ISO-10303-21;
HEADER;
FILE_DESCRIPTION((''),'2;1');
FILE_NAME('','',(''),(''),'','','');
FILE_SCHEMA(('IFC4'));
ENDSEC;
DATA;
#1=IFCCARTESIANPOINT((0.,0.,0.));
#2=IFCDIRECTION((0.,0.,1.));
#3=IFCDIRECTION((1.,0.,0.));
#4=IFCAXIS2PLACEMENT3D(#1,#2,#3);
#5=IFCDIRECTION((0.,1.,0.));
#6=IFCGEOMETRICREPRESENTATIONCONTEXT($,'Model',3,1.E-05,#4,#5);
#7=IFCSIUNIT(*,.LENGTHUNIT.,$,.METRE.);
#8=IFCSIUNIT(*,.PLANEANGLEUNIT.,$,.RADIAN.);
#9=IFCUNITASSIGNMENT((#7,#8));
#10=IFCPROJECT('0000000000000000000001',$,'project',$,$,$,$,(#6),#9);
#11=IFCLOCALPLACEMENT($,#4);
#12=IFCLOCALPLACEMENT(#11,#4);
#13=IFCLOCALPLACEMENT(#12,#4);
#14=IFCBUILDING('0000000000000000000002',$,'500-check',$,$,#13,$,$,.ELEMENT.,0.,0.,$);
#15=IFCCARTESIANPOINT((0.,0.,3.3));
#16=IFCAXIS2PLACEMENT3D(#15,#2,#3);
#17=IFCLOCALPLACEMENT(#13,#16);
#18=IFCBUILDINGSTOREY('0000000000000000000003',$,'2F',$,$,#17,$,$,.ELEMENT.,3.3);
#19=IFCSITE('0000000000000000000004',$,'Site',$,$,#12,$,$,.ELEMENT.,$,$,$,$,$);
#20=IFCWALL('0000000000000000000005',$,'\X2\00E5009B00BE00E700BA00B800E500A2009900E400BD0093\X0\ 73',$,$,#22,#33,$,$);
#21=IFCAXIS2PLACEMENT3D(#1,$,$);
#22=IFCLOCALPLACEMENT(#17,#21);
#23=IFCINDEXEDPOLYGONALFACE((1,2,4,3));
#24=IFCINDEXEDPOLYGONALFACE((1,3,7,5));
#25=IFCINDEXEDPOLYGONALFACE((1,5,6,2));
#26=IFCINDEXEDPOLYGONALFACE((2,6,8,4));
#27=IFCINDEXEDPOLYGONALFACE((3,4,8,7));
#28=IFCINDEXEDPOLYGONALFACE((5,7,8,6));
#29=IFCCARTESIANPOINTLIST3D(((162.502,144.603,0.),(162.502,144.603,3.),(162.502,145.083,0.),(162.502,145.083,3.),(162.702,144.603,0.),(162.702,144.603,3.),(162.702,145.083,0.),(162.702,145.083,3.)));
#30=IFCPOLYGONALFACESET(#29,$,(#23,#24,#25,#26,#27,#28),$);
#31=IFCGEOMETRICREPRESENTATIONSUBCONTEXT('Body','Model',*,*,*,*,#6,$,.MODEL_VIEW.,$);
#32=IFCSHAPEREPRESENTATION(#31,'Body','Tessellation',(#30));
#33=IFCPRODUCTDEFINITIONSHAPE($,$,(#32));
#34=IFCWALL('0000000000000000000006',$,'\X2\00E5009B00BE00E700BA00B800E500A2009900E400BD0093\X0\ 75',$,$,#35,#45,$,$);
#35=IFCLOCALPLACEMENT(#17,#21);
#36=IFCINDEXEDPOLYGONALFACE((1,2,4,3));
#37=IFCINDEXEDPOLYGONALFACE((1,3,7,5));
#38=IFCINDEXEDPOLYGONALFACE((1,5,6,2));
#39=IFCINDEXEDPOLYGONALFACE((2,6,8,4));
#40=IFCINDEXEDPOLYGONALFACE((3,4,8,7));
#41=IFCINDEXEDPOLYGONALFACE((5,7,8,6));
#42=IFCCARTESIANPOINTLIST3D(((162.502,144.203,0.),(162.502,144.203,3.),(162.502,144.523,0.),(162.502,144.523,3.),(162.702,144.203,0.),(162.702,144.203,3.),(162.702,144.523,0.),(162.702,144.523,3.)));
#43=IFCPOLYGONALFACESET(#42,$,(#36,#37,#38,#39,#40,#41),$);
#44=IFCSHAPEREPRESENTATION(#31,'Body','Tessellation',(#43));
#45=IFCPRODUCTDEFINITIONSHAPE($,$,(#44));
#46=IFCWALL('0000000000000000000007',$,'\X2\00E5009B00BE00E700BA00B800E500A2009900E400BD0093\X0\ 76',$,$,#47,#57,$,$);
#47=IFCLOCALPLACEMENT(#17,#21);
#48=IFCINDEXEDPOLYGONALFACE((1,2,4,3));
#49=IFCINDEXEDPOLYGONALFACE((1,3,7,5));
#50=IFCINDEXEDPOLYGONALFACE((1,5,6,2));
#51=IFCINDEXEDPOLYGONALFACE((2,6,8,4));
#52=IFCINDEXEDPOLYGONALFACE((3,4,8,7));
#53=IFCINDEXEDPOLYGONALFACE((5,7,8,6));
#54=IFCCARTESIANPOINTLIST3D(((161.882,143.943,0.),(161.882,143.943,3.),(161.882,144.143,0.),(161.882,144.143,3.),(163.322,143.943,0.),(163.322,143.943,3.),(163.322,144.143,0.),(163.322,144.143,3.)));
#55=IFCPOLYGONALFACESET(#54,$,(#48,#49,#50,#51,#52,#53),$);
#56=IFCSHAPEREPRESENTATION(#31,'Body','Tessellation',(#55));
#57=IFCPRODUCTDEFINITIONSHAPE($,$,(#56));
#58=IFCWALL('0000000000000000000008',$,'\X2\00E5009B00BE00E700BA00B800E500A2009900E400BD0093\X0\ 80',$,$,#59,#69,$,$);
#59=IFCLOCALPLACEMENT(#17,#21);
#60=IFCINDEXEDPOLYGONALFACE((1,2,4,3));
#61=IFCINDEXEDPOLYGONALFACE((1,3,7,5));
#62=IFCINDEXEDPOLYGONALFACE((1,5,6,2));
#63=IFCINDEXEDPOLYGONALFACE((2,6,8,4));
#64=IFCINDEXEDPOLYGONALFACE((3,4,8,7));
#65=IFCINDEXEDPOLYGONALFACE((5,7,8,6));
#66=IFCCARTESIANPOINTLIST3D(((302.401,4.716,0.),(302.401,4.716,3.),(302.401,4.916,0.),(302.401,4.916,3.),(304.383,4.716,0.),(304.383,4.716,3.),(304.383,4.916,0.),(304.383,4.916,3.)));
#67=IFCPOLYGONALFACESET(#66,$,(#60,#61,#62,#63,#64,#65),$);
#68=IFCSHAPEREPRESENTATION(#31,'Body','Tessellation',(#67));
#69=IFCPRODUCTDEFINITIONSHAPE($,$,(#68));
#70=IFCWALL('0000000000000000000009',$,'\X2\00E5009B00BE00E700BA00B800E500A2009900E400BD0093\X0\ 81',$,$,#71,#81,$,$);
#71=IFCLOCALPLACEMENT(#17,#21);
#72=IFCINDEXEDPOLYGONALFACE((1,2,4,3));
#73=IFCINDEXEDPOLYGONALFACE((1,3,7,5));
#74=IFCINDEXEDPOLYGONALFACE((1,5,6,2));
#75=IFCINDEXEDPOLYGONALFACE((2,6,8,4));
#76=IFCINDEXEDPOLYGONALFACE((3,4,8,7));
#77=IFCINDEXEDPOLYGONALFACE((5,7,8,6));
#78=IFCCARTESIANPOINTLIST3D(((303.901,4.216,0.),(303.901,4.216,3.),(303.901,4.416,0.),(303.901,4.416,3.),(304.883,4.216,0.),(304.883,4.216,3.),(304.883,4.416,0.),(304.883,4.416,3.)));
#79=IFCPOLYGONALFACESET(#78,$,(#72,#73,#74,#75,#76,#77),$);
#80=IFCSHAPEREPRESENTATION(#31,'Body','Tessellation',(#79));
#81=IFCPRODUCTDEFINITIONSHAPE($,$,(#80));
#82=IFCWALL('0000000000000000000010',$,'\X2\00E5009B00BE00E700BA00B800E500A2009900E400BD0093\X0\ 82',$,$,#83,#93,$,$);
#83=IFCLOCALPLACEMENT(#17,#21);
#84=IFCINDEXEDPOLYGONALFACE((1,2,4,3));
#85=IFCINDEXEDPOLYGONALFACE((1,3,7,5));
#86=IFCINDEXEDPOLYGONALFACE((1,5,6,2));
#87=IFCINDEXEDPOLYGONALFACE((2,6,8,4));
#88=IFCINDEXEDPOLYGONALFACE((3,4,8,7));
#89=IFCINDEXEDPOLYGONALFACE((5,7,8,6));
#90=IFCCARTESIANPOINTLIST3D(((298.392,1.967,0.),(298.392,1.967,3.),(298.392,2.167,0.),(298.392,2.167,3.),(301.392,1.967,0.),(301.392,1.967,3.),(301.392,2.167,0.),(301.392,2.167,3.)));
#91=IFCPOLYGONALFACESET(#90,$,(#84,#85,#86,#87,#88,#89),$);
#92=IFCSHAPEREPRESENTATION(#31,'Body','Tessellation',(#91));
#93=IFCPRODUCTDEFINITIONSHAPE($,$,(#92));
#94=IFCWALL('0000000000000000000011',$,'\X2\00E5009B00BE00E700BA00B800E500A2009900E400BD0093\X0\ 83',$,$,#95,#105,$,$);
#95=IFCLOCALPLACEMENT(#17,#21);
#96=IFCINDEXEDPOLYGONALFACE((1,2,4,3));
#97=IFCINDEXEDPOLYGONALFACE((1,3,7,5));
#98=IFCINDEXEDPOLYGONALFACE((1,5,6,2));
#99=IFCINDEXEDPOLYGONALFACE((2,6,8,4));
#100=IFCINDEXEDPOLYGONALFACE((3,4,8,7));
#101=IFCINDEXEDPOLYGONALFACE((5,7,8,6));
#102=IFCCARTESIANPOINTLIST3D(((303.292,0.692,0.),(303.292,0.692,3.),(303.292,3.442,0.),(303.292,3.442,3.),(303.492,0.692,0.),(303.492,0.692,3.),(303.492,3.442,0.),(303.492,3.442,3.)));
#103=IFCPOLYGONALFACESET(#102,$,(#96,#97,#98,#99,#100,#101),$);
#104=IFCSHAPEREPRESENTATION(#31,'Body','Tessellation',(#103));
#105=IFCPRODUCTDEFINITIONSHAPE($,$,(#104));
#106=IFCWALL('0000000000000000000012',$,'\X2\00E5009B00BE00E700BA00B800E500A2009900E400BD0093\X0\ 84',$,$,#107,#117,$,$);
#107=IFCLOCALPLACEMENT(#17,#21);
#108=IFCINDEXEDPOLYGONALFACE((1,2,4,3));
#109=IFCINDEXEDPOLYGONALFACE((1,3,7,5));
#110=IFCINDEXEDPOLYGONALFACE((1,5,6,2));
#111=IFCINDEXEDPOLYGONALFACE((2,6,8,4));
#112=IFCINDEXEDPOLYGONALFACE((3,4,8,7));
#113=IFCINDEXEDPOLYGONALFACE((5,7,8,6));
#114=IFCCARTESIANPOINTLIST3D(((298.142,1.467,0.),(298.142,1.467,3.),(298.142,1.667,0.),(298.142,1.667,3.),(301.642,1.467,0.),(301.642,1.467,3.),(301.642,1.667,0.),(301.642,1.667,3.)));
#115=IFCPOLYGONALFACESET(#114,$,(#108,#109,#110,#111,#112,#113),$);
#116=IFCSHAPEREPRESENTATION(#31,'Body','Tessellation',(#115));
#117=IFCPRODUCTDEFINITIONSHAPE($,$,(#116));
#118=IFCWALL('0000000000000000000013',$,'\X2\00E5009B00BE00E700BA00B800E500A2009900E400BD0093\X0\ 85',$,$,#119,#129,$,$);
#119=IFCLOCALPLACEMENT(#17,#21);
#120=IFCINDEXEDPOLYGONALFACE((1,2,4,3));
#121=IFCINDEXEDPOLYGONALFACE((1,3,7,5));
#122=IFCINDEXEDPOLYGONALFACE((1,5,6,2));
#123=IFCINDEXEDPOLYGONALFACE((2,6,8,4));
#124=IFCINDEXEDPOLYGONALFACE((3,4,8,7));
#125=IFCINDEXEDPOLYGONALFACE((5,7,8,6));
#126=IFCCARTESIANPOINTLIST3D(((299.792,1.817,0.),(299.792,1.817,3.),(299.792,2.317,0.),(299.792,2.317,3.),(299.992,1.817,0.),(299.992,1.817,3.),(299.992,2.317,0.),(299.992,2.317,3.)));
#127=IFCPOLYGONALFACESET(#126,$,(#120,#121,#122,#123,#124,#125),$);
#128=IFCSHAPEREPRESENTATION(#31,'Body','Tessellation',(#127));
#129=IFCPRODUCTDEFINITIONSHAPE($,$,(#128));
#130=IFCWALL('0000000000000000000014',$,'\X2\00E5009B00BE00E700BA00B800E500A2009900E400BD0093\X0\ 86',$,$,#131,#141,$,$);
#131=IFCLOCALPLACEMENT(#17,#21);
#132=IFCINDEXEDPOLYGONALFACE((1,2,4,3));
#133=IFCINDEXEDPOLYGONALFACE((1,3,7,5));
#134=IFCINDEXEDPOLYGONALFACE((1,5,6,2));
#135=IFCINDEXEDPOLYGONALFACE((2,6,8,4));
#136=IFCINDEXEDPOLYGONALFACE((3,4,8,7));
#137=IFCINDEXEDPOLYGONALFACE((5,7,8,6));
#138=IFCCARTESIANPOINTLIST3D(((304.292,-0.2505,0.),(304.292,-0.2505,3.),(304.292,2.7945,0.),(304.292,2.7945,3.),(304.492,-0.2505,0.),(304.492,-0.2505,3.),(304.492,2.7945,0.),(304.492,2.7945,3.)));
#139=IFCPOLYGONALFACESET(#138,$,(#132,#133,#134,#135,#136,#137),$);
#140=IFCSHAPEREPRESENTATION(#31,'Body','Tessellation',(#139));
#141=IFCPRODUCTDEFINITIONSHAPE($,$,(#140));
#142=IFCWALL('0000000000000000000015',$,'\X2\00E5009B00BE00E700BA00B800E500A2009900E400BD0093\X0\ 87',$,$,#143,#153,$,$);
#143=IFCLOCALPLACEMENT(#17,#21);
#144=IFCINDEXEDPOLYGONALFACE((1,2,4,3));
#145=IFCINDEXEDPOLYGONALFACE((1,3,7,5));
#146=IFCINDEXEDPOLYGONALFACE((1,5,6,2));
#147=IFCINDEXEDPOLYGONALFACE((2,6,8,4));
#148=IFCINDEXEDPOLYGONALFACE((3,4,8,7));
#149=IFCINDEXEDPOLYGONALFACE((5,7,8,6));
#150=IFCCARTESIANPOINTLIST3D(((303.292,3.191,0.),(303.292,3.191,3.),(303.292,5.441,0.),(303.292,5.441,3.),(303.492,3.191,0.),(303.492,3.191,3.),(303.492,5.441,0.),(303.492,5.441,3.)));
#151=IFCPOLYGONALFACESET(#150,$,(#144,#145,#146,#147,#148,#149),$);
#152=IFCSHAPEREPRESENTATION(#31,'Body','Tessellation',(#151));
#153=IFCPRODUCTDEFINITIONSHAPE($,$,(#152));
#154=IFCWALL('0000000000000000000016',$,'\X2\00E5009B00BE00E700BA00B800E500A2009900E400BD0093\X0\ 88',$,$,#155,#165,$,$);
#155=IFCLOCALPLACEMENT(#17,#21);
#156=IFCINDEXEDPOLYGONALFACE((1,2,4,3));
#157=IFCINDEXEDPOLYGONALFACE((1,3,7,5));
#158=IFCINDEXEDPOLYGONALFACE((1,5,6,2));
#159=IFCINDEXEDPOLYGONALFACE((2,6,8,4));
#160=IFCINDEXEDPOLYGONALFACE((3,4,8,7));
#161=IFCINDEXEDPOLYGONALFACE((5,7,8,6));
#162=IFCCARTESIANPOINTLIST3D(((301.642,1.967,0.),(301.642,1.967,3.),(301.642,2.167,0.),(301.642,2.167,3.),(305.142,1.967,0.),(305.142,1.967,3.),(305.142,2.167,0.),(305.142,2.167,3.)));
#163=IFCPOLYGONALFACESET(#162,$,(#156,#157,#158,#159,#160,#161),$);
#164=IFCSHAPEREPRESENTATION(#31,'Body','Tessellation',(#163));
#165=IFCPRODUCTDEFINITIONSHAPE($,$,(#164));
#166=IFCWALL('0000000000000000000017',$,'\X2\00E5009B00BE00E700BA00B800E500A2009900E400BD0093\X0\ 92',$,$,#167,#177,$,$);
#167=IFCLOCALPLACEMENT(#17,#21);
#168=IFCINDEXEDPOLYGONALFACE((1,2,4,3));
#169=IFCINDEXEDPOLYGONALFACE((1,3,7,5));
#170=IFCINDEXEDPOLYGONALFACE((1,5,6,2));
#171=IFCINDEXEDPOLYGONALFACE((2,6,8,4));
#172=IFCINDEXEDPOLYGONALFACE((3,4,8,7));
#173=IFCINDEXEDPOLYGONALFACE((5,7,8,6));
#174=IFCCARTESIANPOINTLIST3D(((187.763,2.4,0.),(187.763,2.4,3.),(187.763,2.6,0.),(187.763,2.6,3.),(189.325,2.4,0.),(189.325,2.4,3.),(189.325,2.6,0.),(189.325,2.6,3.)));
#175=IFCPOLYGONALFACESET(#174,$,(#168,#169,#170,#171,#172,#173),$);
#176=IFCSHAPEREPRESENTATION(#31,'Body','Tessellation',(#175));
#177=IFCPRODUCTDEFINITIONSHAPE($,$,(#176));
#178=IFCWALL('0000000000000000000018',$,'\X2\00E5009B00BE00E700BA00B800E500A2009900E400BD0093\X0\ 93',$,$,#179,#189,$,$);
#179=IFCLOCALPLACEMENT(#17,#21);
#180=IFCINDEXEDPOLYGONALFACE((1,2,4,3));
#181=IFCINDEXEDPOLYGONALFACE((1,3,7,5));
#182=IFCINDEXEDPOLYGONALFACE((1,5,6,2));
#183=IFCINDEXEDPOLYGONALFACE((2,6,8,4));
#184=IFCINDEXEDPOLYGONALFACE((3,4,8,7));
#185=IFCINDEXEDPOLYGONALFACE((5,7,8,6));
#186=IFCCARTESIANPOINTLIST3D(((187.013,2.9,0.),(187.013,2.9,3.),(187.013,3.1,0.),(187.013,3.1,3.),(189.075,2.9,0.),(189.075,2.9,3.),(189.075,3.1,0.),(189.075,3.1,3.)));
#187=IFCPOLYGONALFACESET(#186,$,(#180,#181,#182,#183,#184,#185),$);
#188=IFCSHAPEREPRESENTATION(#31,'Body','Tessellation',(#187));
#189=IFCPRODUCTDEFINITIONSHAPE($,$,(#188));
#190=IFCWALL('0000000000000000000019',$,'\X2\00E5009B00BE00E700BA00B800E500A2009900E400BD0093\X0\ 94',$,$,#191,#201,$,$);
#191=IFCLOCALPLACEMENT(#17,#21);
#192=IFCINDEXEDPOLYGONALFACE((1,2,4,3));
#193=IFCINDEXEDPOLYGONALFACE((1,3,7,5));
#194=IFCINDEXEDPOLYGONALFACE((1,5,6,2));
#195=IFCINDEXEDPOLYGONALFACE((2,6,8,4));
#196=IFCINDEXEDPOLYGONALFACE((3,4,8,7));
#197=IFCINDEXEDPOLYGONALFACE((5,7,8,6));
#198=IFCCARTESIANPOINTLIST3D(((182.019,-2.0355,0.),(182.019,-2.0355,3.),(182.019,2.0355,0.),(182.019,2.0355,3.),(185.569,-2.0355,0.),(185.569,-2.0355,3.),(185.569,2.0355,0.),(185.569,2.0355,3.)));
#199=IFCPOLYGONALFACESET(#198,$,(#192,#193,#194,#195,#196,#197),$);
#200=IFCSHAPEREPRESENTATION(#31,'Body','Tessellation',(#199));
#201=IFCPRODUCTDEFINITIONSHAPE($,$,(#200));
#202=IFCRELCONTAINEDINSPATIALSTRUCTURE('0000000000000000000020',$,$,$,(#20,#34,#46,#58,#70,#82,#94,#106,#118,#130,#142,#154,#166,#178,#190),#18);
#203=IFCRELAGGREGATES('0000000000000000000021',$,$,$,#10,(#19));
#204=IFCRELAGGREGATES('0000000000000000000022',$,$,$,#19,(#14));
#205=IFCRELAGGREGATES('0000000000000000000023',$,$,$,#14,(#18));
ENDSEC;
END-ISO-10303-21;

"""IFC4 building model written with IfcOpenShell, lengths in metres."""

from ifc_helpers import new_model, si_unit, direction, frame, frame_2d, origin_with_axes, place, context, subcontext, project, spatial, rectangle, extrude, element, save


model = new_model("IFC4")

# Units and contexts
model_context = context("Model", 3, precision=1e-05, world=origin_with_axes(), true_north=direction((0.0, 1.0, 0.0)))
body_context = subcontext(model_context, "Body", "Model", "MODEL_VIEW")
ifc_project = project(units=[si_unit("LENGTHUNIT", "METRE"), si_unit("PLANEANGLEUNIT", "RADIAN")], contexts=[model_context])

# Site, building, storey
placement = place(None, origin_with_axes())
site_placement = place(placement, origin_with_axes())
site = spatial("IfcSite", under=ifc_project, at=site_placement, Name="Site", CompositionType="ELEMENT")
building_placement = place(site_placement, origin_with_axes())
building = spatial("IfcBuilding", under=site, at=building_placement, Name="500-check", CompositionType="ELEMENT", ElevationOfRefHeight=0.0, ElevationOfTerrain=0.0)
storey_placement = place(building_placement, frame((0.0, 0.0, 3.3), z_axis=(0.0, 0.0, 1.0), x_axis=(1.0, 0.0, 0.0)))
storey = spatial("IfcBuildingStorey", under=building, at=storey_placement, Name="2F", CompositionType="ELEMENT", Elevation=3.3)

# Walls
wall_1_placement = place(storey_placement, frame((162.602, 144.843, 0.0), z_axis=(0.0, 0.0, 1.0), x_axis=(0.0, -1.0, 0.0)))
element("IfcWall", 1, at=wall_1_placement, inside=storey, Name="å\u009b¾çº¸å¢\u0099ä½\u0093 73", context=body_context, shape_type="SweptSolid", body=[
    extrude(rectangle(XDim=0.48, YDim=0.2, at=frame_2d((0.0, 0.0), x_axis=(1.0, 0.0, 0.0))), frame((0.0, 0.0, 0.0), z_axis=(0.0, 0.0, 1.0)), (0.0, 0.0, 1.0), 3.0),
])
wall_2_placement = place(storey_placement, frame((162.602, 144.363, 0.0), z_axis=(0.0, 0.0, 1.0), x_axis=(0.0, -1.0, 0.0)))
element("IfcWall", 2, at=wall_2_placement, inside=storey, Name="å\u009b¾çº¸å¢\u0099ä½\u0093 75", context=body_context, shape_type="SweptSolid", body=[
    extrude(rectangle(XDim=0.32, YDim=0.2, at=frame_2d((0.0, 0.0), x_axis=(1.0, 0.0, 0.0))), frame((0.0, 0.0, 0.0), z_axis=(0.0, 0.0, 1.0)), (0.0, 0.0, 1.0), 3.0),
])
wall_3_placement = place(storey_placement, frame((162.602, 144.043, 0.0), z_axis=(0.0, 0.0, 1.0), x_axis=(-1.0, 0.0, 0.0)))
element("IfcWall", 3, at=wall_3_placement, inside=storey, Name="å\u009b¾çº¸å¢\u0099ä½\u0093 76", context=body_context, shape_type="SweptSolid", body=[
    extrude(rectangle(XDim=1.44, YDim=0.2, at=frame_2d((0.0, 0.0), x_axis=(1.0, 0.0, 0.0))), frame((0.0, 0.0, 0.0), z_axis=(0.0, 0.0, 1.0)), (0.0, 0.0, 1.0), 3.0),
])
wall_4_placement = place(storey_placement, frame((303.392, 4.816, 0.0), z_axis=(0.0, 0.0, 1.0), x_axis=(1.0, 0.0, 0.0)))
element("IfcWall", 4, at=wall_4_placement, inside=storey, Name="å\u009b¾çº¸å¢\u0099ä½\u0093 80", context=body_context, shape_type="SweptSolid", body=[
    extrude(rectangle(XDim=1.982, YDim=0.2, at=frame_2d((0.0, 0.0), x_axis=(1.0, 0.0, 0.0))), frame((0.0, 0.0, 0.0), z_axis=(0.0, 0.0, 1.0)), (0.0, 0.0, 1.0), 3.0),
])
wall_5_placement = place(storey_placement, frame((304.392, 4.316, 0.0), z_axis=(0.0, 0.0, 1.0), x_axis=(1.0, 0.0, 0.0)))
element("IfcWall", 5, at=wall_5_placement, inside=storey, Name="å\u009b¾çº¸å¢\u0099ä½\u0093 81", context=body_context, shape_type="SweptSolid", body=[
    extrude(rectangle(XDim=0.982, YDim=0.2, at=frame_2d((0.0, 0.0), x_axis=(1.0, 0.0, 0.0))), frame((0.0, 0.0, 0.0), z_axis=(0.0, 0.0, 1.0)), (0.0, 0.0, 1.0), 3.0),
])
wall_6_placement = place(storey_placement, frame((299.892, 2.067, 0.0), z_axis=(0.0, 0.0, 1.0), x_axis=(1.0, 0.0, 0.0)))
element("IfcWall", 6, at=wall_6_placement, inside=storey, Name="å\u009b¾çº¸å¢\u0099ä½\u0093 82", context=body_context, shape_type="SweptSolid", body=[
    extrude(rectangle(XDim=3.0, YDim=0.2, at=frame_2d((0.0, 0.0), x_axis=(1.0, 0.0, 0.0))), frame((0.0, 0.0, 0.0), z_axis=(0.0, 0.0, 1.0)), (0.0, 0.0, 1.0), 3.0),
])
wall_7_placement = place(storey_placement, frame((303.392, 2.067, 0.0), z_axis=(0.0, 0.0, 1.0), x_axis=(0.0, 1.0, 0.0)))
element("IfcWall", 7, at=wall_7_placement, inside=storey, Name="å\u009b¾çº¸å¢\u0099ä½\u0093 83", context=body_context, shape_type="SweptSolid", body=[
    extrude(rectangle(XDim=2.75, YDim=0.2, at=frame_2d((0.0, 0.0), x_axis=(1.0, 0.0, 0.0))), frame((0.0, 0.0, 0.0), z_axis=(0.0, 0.0, 1.0)), (0.0, 0.0, 1.0), 3.0),
])
wall_8_placement = place(storey_placement, frame((299.892, 1.567, 0.0), z_axis=(0.0, 0.0, 1.0), x_axis=(1.0, 0.0, 0.0)))
element("IfcWall", 8, at=wall_8_placement, inside=storey, Name="å\u009b¾çº¸å¢\u0099ä½\u0093 84", context=body_context, shape_type="SweptSolid", body=[
    extrude(rectangle(XDim=3.5, YDim=0.2, at=frame_2d((0.0, 0.0), x_axis=(1.0, 0.0, 0.0))), frame((0.0, 0.0, 0.0), z_axis=(0.0, 0.0, 1.0)), (0.0, 0.0, 1.0), 3.0),
])
wall_9_placement = place(storey_placement, frame((299.892, 2.067, 0.0), z_axis=(0.0, 0.0, 1.0), x_axis=(0.0, -1.0, 0.0)))
element("IfcWall", 9, at=wall_9_placement, inside=storey, Name="å\u009b¾çº¸å¢\u0099ä½\u0093 85", context=body_context, shape_type="SweptSolid", body=[
    extrude(rectangle(XDim=0.5, YDim=0.2, at=frame_2d((0.0, 0.0), x_axis=(1.0, 0.0, 0.0))), frame((0.0, 0.0, 0.0), z_axis=(0.0, 0.0, 1.0)), (0.0, 0.0, 1.0), 3.0),
])
wall_10_placement = place(storey_placement, frame((304.392, 1.272, 0.0), z_axis=(0.0, 0.0, 1.0), x_axis=(0.0, 1.0, 0.0)))
element("IfcWall", 10, at=wall_10_placement, inside=storey, Name="å\u009b¾çº¸å¢\u0099ä½\u0093 86", context=body_context, shape_type="SweptSolid", body=[
    extrude(rectangle(XDim=3.045, YDim=0.2, at=frame_2d((0.0, 0.0), x_axis=(1.0, 0.0, 0.0))), frame((0.0, 0.0, 0.0), z_axis=(0.0, 0.0, 1.0)), (0.0, 0.0, 1.0), 3.0),
])
wall_11_placement = place(storey_placement, frame((303.392, 4.316, 0.0), z_axis=(0.0, 0.0, 1.0), x_axis=(0.0, -1.0, 0.0)))
element("IfcWall", 11, at=wall_11_placement, inside=storey, Name="å\u009b¾çº¸å¢\u0099ä½\u0093 87", context=body_context, shape_type="SweptSolid", body=[
    extrude(rectangle(XDim=2.25, YDim=0.2, at=frame_2d((0.0, 0.0), x_axis=(1.0, 0.0, 0.0))), frame((0.0, 0.0, 0.0), z_axis=(0.0, 0.0, 1.0)), (0.0, 0.0, 1.0), 3.0),
])
wall_12_placement = place(storey_placement, frame((303.392, 2.067, 0.0), z_axis=(0.0, 0.0, 1.0), x_axis=(-1.0, 0.0, 0.0)))
element("IfcWall", 12, at=wall_12_placement, inside=storey, Name="å\u009b¾çº¸å¢\u0099ä½\u0093 88", context=body_context, shape_type="SweptSolid", body=[
    extrude(rectangle(XDim=3.5, YDim=0.2, at=frame_2d((0.0, 0.0), x_axis=(1.0, 0.0, 0.0))), frame((0.0, 0.0, 0.0), z_axis=(0.0, 0.0, 1.0)), (0.0, 0.0, 1.0), 3.0),
])
wall_13_placement = place(storey_placement, frame((188.544, 2.5, 0.0), z_axis=(0.0, 0.0, 1.0), x_axis=(1.0, 0.0, 0.0)))
element("IfcWall", 13, at=wall_13_placement, inside=storey, Name="å\u009b¾çº¸å¢\u0099ä½\u0093 92", context=body_context, shape_type="SweptSolid", body=[
    extrude(rectangle(XDim=1.562, YDim=0.2, at=frame_2d((0.0, 0.0), x_axis=(1.0, 0.0, 0.0))), frame((0.0, 0.0, 0.0), z_axis=(0.0, 0.0, 1.0)), (0.0, 0.0, 1.0), 3.0),
])
wall_14_placement = place(storey_placement, frame((188.044, 3.0, 0.0), z_axis=(0.0, 0.0, 1.0), x_axis=(1.0, 0.0, 0.0)))
element("IfcWall", 14, at=wall_14_placement, inside=storey, Name="å\u009b¾çº¸å¢\u0099ä½\u0093 93", context=body_context, shape_type="SweptSolid", body=[
    extrude(rectangle(XDim=2.062, YDim=0.2, at=frame_2d((0.0, 0.0), x_axis=(1.0, 0.0, 0.0))), frame((0.0, 0.0, 0.0), z_axis=(0.0, 0.0, 1.0)), (0.0, 0.0, 1.0), 3.0),
])
wall_15_placement = place(storey_placement, frame((183.794, 0.0, 0.0), z_axis=(0.0, 0.0, 1.0), x_axis=(1.0, 0.0, 0.0)))
element("IfcWall", 15, at=wall_15_placement, inside=storey, Name="å\u009b¾çº¸å¢\u0099ä½\u0093 94", context=body_context, shape_type="SweptSolid", body=[
    extrude(rectangle(XDim=3.55, YDim=4.071, at=frame_2d((0.0, 0.0), x_axis=(1.0, 0.0, 0.0))), frame((0.0, 0.0, 0.0), z_axis=(0.0, 0.0, 1.0)), (0.0, 0.0, 1.0), 3.0),
])

save(model, "model.ifc")
